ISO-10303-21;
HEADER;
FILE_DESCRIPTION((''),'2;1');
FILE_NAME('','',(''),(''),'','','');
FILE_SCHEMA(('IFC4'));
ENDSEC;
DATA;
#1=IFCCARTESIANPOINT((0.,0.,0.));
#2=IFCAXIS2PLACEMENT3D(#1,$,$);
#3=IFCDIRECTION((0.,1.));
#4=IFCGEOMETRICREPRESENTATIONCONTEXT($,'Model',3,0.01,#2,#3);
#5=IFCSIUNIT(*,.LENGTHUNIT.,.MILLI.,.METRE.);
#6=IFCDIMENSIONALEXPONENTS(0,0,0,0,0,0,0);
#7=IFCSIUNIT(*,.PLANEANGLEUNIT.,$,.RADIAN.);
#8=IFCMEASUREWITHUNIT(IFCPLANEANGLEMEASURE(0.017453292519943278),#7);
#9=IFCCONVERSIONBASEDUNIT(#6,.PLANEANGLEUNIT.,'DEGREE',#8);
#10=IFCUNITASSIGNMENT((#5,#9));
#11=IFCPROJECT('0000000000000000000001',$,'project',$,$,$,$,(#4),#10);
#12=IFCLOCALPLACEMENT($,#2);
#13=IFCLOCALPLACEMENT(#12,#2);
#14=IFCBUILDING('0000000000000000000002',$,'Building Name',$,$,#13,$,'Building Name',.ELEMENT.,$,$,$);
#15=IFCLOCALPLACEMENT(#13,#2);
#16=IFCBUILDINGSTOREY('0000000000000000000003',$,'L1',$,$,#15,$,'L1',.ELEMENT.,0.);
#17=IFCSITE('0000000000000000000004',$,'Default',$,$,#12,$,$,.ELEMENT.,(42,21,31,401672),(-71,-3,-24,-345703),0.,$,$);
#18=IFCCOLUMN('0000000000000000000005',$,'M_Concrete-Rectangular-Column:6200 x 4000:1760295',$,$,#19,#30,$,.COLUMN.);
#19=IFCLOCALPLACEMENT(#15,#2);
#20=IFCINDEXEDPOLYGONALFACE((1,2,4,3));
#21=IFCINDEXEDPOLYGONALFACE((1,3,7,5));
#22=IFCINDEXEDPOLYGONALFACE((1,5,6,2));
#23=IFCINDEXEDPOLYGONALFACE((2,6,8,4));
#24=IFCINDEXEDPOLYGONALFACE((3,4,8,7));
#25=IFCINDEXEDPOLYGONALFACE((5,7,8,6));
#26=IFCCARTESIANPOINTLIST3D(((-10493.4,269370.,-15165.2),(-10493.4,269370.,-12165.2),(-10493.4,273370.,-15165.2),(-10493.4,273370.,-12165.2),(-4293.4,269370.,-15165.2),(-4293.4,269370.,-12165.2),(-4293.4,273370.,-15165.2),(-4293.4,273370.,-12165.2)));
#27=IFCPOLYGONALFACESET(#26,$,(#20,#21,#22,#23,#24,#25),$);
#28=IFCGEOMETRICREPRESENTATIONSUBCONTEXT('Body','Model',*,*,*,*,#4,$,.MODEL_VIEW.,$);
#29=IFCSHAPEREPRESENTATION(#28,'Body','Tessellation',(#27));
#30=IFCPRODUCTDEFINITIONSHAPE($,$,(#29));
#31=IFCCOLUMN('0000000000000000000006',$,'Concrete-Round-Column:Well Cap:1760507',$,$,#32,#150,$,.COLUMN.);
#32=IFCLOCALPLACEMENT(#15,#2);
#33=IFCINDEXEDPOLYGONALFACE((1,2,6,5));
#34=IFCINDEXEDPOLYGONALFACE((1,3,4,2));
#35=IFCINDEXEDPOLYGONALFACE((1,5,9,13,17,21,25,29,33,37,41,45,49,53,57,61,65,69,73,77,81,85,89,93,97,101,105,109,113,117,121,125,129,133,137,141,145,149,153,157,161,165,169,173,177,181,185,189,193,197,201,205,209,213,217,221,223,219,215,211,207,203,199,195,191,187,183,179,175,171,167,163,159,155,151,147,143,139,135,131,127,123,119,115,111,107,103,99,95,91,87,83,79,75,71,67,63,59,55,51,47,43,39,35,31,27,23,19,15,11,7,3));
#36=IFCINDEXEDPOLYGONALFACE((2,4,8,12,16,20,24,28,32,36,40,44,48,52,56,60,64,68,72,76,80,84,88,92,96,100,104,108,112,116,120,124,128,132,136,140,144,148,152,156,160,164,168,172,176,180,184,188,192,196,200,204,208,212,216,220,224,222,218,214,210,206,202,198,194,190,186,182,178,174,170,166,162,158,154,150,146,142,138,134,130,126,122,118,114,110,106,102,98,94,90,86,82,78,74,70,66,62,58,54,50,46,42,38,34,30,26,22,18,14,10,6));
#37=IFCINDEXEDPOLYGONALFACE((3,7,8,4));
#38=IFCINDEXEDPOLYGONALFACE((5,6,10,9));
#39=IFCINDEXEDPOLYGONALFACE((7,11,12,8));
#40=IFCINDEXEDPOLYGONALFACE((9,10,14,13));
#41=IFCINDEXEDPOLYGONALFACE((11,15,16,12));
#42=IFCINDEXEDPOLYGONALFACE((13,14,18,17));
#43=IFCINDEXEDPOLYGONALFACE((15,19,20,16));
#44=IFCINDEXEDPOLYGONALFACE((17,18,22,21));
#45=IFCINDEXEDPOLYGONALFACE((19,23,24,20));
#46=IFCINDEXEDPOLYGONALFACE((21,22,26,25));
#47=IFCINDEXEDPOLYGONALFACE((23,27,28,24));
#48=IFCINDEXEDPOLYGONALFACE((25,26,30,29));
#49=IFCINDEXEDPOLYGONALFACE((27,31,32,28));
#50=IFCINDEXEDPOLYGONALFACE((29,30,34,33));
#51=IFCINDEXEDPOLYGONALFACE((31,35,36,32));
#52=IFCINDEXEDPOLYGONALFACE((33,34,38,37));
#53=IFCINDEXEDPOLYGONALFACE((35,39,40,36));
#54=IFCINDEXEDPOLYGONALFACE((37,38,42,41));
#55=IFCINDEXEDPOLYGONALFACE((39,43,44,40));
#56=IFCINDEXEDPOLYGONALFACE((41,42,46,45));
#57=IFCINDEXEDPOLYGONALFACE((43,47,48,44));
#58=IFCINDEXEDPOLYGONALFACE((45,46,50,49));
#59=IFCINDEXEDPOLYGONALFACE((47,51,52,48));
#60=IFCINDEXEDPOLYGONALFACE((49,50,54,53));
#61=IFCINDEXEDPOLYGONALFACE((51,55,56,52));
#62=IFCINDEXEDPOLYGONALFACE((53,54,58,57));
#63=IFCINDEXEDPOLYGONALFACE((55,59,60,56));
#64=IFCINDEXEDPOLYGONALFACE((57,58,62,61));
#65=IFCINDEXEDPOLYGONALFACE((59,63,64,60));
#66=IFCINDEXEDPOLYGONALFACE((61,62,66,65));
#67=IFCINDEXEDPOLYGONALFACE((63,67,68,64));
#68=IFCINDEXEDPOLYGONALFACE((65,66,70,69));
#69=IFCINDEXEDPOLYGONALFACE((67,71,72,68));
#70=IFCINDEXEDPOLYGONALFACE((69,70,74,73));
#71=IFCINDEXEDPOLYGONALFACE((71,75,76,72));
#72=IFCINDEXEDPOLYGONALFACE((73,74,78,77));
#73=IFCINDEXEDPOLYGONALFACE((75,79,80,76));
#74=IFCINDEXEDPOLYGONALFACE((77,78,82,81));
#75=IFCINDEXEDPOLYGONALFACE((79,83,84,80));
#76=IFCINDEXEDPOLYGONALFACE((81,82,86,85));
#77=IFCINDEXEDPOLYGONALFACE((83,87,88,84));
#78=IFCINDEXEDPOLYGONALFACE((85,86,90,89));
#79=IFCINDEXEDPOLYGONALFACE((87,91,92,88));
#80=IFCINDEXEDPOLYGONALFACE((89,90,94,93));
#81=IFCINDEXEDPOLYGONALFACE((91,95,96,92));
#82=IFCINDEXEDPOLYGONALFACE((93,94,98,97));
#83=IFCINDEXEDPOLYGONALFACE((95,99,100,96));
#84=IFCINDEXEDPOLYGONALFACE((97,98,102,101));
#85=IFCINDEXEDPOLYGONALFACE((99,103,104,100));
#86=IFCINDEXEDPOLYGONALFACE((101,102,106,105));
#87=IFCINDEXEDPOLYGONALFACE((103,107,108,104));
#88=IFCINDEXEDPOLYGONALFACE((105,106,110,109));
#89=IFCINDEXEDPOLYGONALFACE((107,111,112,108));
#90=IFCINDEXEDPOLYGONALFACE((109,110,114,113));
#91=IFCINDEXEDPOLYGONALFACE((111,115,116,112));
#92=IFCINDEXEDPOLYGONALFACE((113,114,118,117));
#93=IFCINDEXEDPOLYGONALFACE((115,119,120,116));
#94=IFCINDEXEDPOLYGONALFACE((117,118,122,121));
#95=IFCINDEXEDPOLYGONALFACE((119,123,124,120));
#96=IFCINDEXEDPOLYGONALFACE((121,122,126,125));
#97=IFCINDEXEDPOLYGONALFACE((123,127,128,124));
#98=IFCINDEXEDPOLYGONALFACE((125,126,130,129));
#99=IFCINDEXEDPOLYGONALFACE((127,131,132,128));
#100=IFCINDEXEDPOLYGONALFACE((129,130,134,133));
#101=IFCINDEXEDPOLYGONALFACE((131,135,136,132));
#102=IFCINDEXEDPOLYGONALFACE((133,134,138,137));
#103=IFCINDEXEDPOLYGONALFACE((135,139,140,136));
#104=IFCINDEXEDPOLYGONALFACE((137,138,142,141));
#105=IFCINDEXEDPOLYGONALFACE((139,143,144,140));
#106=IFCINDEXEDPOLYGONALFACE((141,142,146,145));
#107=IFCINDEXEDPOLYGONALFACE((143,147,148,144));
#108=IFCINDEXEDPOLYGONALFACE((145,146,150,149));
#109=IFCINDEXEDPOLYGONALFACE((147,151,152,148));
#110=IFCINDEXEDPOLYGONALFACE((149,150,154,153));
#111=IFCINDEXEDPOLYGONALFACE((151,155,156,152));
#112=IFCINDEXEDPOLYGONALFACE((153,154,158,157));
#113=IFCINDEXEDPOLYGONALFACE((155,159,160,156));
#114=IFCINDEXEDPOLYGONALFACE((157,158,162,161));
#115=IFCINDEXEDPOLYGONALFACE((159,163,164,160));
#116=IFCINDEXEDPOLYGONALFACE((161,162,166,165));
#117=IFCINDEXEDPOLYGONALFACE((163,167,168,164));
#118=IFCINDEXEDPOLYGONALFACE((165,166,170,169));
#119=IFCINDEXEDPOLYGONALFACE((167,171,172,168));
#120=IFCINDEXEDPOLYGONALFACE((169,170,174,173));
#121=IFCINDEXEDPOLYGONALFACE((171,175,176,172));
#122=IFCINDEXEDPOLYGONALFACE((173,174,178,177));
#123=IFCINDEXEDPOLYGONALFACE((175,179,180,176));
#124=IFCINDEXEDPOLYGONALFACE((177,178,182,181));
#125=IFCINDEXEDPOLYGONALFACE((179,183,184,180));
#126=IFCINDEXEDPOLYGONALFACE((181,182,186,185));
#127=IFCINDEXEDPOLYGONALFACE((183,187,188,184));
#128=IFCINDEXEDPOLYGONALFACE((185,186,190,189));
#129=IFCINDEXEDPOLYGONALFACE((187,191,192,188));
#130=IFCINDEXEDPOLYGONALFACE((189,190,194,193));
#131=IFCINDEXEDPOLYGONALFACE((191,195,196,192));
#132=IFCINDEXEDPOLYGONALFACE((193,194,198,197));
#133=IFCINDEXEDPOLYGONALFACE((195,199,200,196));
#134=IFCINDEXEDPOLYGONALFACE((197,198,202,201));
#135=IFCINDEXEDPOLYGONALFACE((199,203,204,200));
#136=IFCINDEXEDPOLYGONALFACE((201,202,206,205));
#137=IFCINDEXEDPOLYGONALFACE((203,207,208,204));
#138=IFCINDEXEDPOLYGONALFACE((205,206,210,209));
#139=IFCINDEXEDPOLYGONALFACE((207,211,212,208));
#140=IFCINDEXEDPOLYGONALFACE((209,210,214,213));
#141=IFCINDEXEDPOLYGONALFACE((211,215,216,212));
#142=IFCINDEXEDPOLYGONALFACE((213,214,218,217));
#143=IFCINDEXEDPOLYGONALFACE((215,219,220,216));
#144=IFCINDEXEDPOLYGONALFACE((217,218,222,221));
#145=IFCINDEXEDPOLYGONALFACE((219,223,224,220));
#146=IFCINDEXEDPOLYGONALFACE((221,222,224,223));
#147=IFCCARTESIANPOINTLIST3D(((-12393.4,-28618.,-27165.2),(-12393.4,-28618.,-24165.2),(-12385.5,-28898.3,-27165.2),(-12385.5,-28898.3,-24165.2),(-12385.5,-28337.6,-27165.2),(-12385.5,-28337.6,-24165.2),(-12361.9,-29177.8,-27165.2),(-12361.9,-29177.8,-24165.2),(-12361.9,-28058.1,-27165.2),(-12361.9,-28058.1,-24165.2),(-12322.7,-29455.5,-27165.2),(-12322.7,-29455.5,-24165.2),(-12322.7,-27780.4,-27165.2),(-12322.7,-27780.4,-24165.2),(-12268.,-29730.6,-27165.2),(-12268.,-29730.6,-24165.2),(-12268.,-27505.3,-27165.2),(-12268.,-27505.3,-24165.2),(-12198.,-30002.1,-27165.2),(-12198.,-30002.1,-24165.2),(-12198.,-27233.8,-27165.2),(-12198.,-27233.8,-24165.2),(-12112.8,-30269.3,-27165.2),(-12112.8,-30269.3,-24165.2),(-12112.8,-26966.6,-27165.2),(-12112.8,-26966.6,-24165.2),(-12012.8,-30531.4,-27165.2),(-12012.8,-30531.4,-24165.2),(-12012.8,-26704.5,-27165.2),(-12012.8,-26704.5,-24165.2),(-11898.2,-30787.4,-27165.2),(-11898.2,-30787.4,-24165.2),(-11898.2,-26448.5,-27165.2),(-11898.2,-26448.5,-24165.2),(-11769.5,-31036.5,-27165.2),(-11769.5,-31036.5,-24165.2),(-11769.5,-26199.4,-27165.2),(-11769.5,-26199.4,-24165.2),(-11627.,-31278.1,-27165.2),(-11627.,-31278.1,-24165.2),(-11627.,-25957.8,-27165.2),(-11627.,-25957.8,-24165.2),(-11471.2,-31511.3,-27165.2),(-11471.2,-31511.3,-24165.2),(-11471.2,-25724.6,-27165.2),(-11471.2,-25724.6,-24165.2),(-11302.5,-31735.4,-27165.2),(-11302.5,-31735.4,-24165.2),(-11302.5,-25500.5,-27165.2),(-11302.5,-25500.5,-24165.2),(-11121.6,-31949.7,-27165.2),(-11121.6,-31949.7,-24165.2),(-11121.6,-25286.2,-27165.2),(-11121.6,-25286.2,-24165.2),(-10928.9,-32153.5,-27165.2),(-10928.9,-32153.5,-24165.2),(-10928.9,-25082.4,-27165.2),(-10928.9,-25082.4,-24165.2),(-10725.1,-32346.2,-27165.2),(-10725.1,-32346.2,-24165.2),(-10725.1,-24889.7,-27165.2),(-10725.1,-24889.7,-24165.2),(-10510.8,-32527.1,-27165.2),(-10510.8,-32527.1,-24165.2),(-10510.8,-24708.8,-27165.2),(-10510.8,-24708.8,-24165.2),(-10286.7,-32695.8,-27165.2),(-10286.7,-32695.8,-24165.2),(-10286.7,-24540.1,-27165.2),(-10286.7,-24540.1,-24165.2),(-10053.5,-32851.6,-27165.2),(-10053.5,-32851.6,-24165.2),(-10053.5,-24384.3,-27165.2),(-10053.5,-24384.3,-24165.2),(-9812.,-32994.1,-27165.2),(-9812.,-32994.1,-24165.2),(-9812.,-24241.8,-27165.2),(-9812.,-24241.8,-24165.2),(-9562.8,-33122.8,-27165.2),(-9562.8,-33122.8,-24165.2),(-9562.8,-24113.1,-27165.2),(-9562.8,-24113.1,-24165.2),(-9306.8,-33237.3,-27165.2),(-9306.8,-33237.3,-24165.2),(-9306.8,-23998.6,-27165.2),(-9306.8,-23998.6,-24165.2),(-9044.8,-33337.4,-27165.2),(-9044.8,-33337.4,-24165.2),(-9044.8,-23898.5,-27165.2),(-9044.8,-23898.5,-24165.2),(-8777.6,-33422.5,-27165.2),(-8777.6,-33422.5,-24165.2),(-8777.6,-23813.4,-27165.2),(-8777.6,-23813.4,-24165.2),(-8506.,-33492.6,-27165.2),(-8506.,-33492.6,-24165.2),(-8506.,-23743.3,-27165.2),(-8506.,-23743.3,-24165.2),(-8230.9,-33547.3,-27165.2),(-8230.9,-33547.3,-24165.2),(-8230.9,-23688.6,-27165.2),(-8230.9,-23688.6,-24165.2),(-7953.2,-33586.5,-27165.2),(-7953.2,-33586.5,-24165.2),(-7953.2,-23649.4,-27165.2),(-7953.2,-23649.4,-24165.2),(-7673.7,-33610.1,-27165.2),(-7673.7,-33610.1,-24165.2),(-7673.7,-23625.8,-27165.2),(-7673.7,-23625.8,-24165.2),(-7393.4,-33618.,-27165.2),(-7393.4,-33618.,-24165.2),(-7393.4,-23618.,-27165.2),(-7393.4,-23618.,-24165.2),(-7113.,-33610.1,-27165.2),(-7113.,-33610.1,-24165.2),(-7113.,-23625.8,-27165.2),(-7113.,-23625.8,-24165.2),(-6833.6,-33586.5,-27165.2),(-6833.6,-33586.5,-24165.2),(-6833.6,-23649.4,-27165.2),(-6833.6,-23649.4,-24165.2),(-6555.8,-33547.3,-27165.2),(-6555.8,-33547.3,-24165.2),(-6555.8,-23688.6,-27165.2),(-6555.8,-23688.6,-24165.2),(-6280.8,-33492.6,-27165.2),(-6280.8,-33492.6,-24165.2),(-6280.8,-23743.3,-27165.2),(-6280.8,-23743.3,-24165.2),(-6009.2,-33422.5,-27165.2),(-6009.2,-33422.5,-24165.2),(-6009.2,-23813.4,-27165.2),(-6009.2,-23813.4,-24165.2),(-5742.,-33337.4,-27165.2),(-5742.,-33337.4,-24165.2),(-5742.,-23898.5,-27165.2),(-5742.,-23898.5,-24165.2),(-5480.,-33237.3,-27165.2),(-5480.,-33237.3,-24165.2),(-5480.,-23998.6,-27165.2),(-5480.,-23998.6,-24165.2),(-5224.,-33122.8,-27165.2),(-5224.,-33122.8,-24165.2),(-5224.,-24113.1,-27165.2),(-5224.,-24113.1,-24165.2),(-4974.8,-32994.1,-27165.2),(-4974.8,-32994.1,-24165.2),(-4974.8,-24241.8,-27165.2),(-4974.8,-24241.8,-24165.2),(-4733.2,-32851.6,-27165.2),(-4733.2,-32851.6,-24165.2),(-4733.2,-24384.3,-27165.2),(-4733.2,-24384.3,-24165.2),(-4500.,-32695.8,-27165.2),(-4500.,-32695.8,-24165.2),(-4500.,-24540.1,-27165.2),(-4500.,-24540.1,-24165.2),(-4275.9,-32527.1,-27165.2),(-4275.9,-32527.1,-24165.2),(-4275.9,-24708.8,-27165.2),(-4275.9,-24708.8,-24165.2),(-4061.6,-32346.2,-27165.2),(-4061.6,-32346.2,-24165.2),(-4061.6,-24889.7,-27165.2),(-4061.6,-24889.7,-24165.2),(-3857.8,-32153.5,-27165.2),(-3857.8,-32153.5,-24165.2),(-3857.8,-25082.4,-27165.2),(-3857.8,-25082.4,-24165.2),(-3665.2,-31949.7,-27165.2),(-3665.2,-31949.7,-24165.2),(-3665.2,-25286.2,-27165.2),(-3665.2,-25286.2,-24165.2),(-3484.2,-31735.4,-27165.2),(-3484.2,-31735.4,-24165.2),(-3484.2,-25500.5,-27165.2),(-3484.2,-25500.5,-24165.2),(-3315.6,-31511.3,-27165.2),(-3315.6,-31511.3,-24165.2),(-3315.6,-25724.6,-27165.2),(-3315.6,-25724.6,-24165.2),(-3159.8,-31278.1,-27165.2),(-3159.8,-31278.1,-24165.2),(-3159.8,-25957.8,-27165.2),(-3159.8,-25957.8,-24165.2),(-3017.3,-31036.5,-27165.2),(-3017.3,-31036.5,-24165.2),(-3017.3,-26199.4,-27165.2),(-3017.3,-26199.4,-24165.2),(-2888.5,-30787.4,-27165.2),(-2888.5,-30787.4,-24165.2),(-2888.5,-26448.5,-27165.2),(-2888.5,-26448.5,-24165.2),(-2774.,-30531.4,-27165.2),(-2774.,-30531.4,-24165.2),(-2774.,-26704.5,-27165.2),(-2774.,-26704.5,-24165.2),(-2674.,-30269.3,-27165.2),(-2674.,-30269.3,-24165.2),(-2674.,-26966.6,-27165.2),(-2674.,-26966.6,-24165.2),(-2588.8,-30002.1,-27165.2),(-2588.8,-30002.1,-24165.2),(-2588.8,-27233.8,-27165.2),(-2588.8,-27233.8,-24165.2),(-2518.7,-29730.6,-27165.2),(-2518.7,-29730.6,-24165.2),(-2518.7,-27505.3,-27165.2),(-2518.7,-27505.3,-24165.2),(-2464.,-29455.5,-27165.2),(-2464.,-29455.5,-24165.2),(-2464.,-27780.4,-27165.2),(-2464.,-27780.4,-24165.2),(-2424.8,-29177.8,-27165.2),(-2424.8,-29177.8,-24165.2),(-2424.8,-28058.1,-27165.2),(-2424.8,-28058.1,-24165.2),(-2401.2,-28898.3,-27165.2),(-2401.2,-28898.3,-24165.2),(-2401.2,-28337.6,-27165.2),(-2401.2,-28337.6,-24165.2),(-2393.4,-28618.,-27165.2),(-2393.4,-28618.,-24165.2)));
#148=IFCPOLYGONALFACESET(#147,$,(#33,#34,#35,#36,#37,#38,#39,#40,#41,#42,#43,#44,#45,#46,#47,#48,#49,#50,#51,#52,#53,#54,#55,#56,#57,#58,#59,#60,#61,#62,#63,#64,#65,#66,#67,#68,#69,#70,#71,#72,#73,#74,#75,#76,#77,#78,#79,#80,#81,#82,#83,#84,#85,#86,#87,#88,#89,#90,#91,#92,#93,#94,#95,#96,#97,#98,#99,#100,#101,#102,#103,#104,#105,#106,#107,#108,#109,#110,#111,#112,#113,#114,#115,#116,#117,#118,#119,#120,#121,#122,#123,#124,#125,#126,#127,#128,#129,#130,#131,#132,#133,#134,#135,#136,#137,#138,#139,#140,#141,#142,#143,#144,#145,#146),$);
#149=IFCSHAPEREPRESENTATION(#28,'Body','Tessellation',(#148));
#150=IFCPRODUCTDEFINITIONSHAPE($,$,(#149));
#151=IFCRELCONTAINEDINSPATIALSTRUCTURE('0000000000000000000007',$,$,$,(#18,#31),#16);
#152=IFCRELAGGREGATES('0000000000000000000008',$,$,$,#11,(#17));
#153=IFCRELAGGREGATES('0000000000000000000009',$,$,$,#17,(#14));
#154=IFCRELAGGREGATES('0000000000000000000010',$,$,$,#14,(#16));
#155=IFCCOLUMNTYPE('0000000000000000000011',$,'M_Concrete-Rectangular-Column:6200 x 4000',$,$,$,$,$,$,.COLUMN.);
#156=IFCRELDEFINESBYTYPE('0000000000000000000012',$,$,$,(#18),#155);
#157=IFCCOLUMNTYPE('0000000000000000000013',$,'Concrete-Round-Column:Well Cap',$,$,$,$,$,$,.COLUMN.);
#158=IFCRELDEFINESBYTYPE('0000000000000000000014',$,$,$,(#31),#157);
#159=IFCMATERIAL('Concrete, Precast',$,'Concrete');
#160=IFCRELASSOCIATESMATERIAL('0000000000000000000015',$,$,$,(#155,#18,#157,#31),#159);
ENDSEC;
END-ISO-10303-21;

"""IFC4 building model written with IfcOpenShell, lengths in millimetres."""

from ifc_helpers import new_model, entity, si_unit, converted_unit, direction, frame, origin, place, context, subcontext, project, spatial, arc, indexed_curve, outline, extrude, source, transform, mapped, material, type_object, type_shapes, element, save


model = new_model("IFC4")

# Units and contexts
model_context = context("Model", 3, precision=0.01, world=origin(), true_north=direction((0.0, 1.0)))
body_context = subcontext(model_context, "Body", "Model", "MODEL_VIEW")
ifc_project = project(units=[si_unit("LENGTHUNIT", "METRE", prefix="MILLI"), converted_unit("PLANEANGLEUNIT", "DEGREE", entity("IfcPlaneAngleMeasure", 0.017453292519943278), si_unit("PLANEANGLEUNIT", "RADIAN"), dimensions=[0, 0, 0, 0, 0, 0, 0])], contexts=[model_context])

# Site, building, storey
site_placement = place(None, origin())
site = spatial("IfcSite", under=ifc_project, at=site_placement, Name="Default", CompositionType="ELEMENT", RefLatitude=(42, 21, 31, 401672), RefLongitude=(-71, -3, -24, -345703), RefElevation=0.0)
building_placement = place(site_placement, origin())
building = spatial("IfcBuilding", under=site, at=building_placement, Name="Building Name", LongName="Building Name", CompositionType="ELEMENT")
storey_placement = place(building_placement, origin())
storey = spatial("IfcBuildingStorey", under=building, at=storey_placement, Name="L1", LongName="L1", CompositionType="ELEMENT", Elevation=0.0)

# Columns
ifc_material_1 = material(Name="Concrete, Precast", Category="Concrete")
column_type_1 = type_object("IfcColumnType", Name="M_Concrete-Rectangular-Column:6200 x 4000", PredefinedType="COLUMN", material=ifc_material_1)
shared_shape_1 = source(origin(), body_context, "Body", "SweptSolid", [
    extrude(outline(indexed_curve([(-2000.0, -3100.0), (2000.0, -3100.0), (2000.0, 3100.0), (-2000.0, 3100.0), (-2000.0, -3100.0)], self_intersect=False)), frame((-7393.4, 271370.0, -15165.2), z_axis=(0.0, 0.0, 1.0), x_axis=(0.0, -1.0, 0.0)), (0.0, 0.0, 1.0), 3000.0),
])
type_shapes(column_type_1, [shared_shape_1])
column_1_placement = place(storey_placement, origin())
element("IfcColumn", 1, at=column_1_placement, inside=storey, type_object=column_type_1, material=ifc_material_1, Name="M_Concrete-Rectangular-Column:6200 x 4000:1760295", PredefinedType="COLUMN", context=body_context, shape_type="MappedRepresentation", body=[
    mapped(shared_shape_1, transform((0.0, 0.0, 0.0), scale=1.0)),
])
column_type_2 = type_object("IfcColumnType", Name="Concrete-Round-Column:Well Cap", PredefinedType="COLUMN", material=ifc_material_1)
shared_shape_2 = source(origin(), body_context, "Body", "SweptSolid", [
    extrude(outline(indexed_curve([(5000.0, 0.0), (0.0, 5000.0), (-5000.0, 0.0), (0.0, -5000.0)], segments=[arc(1, 2, 3), arc(3, 4, 1)], self_intersect=False)), frame((-7393.4, -28618.0, -27165.2)), (0.0, 0.0, 1.0), 3000.0),
])
type_shapes(column_type_2, [shared_shape_2])
column_2_placement = place(storey_placement, origin())
element("IfcColumn", 2, at=column_2_placement, inside=storey, type_object=column_type_2, material=ifc_material_1, Name="Concrete-Round-Column:Well Cap:1760507", PredefinedType="COLUMN", context=body_context, shape_type="MappedRepresentation", body=[
    mapped(shared_shape_2, transform((0.0, 0.0, 0.0), scale=1.0)),
])

save(model, "model.ifc")
